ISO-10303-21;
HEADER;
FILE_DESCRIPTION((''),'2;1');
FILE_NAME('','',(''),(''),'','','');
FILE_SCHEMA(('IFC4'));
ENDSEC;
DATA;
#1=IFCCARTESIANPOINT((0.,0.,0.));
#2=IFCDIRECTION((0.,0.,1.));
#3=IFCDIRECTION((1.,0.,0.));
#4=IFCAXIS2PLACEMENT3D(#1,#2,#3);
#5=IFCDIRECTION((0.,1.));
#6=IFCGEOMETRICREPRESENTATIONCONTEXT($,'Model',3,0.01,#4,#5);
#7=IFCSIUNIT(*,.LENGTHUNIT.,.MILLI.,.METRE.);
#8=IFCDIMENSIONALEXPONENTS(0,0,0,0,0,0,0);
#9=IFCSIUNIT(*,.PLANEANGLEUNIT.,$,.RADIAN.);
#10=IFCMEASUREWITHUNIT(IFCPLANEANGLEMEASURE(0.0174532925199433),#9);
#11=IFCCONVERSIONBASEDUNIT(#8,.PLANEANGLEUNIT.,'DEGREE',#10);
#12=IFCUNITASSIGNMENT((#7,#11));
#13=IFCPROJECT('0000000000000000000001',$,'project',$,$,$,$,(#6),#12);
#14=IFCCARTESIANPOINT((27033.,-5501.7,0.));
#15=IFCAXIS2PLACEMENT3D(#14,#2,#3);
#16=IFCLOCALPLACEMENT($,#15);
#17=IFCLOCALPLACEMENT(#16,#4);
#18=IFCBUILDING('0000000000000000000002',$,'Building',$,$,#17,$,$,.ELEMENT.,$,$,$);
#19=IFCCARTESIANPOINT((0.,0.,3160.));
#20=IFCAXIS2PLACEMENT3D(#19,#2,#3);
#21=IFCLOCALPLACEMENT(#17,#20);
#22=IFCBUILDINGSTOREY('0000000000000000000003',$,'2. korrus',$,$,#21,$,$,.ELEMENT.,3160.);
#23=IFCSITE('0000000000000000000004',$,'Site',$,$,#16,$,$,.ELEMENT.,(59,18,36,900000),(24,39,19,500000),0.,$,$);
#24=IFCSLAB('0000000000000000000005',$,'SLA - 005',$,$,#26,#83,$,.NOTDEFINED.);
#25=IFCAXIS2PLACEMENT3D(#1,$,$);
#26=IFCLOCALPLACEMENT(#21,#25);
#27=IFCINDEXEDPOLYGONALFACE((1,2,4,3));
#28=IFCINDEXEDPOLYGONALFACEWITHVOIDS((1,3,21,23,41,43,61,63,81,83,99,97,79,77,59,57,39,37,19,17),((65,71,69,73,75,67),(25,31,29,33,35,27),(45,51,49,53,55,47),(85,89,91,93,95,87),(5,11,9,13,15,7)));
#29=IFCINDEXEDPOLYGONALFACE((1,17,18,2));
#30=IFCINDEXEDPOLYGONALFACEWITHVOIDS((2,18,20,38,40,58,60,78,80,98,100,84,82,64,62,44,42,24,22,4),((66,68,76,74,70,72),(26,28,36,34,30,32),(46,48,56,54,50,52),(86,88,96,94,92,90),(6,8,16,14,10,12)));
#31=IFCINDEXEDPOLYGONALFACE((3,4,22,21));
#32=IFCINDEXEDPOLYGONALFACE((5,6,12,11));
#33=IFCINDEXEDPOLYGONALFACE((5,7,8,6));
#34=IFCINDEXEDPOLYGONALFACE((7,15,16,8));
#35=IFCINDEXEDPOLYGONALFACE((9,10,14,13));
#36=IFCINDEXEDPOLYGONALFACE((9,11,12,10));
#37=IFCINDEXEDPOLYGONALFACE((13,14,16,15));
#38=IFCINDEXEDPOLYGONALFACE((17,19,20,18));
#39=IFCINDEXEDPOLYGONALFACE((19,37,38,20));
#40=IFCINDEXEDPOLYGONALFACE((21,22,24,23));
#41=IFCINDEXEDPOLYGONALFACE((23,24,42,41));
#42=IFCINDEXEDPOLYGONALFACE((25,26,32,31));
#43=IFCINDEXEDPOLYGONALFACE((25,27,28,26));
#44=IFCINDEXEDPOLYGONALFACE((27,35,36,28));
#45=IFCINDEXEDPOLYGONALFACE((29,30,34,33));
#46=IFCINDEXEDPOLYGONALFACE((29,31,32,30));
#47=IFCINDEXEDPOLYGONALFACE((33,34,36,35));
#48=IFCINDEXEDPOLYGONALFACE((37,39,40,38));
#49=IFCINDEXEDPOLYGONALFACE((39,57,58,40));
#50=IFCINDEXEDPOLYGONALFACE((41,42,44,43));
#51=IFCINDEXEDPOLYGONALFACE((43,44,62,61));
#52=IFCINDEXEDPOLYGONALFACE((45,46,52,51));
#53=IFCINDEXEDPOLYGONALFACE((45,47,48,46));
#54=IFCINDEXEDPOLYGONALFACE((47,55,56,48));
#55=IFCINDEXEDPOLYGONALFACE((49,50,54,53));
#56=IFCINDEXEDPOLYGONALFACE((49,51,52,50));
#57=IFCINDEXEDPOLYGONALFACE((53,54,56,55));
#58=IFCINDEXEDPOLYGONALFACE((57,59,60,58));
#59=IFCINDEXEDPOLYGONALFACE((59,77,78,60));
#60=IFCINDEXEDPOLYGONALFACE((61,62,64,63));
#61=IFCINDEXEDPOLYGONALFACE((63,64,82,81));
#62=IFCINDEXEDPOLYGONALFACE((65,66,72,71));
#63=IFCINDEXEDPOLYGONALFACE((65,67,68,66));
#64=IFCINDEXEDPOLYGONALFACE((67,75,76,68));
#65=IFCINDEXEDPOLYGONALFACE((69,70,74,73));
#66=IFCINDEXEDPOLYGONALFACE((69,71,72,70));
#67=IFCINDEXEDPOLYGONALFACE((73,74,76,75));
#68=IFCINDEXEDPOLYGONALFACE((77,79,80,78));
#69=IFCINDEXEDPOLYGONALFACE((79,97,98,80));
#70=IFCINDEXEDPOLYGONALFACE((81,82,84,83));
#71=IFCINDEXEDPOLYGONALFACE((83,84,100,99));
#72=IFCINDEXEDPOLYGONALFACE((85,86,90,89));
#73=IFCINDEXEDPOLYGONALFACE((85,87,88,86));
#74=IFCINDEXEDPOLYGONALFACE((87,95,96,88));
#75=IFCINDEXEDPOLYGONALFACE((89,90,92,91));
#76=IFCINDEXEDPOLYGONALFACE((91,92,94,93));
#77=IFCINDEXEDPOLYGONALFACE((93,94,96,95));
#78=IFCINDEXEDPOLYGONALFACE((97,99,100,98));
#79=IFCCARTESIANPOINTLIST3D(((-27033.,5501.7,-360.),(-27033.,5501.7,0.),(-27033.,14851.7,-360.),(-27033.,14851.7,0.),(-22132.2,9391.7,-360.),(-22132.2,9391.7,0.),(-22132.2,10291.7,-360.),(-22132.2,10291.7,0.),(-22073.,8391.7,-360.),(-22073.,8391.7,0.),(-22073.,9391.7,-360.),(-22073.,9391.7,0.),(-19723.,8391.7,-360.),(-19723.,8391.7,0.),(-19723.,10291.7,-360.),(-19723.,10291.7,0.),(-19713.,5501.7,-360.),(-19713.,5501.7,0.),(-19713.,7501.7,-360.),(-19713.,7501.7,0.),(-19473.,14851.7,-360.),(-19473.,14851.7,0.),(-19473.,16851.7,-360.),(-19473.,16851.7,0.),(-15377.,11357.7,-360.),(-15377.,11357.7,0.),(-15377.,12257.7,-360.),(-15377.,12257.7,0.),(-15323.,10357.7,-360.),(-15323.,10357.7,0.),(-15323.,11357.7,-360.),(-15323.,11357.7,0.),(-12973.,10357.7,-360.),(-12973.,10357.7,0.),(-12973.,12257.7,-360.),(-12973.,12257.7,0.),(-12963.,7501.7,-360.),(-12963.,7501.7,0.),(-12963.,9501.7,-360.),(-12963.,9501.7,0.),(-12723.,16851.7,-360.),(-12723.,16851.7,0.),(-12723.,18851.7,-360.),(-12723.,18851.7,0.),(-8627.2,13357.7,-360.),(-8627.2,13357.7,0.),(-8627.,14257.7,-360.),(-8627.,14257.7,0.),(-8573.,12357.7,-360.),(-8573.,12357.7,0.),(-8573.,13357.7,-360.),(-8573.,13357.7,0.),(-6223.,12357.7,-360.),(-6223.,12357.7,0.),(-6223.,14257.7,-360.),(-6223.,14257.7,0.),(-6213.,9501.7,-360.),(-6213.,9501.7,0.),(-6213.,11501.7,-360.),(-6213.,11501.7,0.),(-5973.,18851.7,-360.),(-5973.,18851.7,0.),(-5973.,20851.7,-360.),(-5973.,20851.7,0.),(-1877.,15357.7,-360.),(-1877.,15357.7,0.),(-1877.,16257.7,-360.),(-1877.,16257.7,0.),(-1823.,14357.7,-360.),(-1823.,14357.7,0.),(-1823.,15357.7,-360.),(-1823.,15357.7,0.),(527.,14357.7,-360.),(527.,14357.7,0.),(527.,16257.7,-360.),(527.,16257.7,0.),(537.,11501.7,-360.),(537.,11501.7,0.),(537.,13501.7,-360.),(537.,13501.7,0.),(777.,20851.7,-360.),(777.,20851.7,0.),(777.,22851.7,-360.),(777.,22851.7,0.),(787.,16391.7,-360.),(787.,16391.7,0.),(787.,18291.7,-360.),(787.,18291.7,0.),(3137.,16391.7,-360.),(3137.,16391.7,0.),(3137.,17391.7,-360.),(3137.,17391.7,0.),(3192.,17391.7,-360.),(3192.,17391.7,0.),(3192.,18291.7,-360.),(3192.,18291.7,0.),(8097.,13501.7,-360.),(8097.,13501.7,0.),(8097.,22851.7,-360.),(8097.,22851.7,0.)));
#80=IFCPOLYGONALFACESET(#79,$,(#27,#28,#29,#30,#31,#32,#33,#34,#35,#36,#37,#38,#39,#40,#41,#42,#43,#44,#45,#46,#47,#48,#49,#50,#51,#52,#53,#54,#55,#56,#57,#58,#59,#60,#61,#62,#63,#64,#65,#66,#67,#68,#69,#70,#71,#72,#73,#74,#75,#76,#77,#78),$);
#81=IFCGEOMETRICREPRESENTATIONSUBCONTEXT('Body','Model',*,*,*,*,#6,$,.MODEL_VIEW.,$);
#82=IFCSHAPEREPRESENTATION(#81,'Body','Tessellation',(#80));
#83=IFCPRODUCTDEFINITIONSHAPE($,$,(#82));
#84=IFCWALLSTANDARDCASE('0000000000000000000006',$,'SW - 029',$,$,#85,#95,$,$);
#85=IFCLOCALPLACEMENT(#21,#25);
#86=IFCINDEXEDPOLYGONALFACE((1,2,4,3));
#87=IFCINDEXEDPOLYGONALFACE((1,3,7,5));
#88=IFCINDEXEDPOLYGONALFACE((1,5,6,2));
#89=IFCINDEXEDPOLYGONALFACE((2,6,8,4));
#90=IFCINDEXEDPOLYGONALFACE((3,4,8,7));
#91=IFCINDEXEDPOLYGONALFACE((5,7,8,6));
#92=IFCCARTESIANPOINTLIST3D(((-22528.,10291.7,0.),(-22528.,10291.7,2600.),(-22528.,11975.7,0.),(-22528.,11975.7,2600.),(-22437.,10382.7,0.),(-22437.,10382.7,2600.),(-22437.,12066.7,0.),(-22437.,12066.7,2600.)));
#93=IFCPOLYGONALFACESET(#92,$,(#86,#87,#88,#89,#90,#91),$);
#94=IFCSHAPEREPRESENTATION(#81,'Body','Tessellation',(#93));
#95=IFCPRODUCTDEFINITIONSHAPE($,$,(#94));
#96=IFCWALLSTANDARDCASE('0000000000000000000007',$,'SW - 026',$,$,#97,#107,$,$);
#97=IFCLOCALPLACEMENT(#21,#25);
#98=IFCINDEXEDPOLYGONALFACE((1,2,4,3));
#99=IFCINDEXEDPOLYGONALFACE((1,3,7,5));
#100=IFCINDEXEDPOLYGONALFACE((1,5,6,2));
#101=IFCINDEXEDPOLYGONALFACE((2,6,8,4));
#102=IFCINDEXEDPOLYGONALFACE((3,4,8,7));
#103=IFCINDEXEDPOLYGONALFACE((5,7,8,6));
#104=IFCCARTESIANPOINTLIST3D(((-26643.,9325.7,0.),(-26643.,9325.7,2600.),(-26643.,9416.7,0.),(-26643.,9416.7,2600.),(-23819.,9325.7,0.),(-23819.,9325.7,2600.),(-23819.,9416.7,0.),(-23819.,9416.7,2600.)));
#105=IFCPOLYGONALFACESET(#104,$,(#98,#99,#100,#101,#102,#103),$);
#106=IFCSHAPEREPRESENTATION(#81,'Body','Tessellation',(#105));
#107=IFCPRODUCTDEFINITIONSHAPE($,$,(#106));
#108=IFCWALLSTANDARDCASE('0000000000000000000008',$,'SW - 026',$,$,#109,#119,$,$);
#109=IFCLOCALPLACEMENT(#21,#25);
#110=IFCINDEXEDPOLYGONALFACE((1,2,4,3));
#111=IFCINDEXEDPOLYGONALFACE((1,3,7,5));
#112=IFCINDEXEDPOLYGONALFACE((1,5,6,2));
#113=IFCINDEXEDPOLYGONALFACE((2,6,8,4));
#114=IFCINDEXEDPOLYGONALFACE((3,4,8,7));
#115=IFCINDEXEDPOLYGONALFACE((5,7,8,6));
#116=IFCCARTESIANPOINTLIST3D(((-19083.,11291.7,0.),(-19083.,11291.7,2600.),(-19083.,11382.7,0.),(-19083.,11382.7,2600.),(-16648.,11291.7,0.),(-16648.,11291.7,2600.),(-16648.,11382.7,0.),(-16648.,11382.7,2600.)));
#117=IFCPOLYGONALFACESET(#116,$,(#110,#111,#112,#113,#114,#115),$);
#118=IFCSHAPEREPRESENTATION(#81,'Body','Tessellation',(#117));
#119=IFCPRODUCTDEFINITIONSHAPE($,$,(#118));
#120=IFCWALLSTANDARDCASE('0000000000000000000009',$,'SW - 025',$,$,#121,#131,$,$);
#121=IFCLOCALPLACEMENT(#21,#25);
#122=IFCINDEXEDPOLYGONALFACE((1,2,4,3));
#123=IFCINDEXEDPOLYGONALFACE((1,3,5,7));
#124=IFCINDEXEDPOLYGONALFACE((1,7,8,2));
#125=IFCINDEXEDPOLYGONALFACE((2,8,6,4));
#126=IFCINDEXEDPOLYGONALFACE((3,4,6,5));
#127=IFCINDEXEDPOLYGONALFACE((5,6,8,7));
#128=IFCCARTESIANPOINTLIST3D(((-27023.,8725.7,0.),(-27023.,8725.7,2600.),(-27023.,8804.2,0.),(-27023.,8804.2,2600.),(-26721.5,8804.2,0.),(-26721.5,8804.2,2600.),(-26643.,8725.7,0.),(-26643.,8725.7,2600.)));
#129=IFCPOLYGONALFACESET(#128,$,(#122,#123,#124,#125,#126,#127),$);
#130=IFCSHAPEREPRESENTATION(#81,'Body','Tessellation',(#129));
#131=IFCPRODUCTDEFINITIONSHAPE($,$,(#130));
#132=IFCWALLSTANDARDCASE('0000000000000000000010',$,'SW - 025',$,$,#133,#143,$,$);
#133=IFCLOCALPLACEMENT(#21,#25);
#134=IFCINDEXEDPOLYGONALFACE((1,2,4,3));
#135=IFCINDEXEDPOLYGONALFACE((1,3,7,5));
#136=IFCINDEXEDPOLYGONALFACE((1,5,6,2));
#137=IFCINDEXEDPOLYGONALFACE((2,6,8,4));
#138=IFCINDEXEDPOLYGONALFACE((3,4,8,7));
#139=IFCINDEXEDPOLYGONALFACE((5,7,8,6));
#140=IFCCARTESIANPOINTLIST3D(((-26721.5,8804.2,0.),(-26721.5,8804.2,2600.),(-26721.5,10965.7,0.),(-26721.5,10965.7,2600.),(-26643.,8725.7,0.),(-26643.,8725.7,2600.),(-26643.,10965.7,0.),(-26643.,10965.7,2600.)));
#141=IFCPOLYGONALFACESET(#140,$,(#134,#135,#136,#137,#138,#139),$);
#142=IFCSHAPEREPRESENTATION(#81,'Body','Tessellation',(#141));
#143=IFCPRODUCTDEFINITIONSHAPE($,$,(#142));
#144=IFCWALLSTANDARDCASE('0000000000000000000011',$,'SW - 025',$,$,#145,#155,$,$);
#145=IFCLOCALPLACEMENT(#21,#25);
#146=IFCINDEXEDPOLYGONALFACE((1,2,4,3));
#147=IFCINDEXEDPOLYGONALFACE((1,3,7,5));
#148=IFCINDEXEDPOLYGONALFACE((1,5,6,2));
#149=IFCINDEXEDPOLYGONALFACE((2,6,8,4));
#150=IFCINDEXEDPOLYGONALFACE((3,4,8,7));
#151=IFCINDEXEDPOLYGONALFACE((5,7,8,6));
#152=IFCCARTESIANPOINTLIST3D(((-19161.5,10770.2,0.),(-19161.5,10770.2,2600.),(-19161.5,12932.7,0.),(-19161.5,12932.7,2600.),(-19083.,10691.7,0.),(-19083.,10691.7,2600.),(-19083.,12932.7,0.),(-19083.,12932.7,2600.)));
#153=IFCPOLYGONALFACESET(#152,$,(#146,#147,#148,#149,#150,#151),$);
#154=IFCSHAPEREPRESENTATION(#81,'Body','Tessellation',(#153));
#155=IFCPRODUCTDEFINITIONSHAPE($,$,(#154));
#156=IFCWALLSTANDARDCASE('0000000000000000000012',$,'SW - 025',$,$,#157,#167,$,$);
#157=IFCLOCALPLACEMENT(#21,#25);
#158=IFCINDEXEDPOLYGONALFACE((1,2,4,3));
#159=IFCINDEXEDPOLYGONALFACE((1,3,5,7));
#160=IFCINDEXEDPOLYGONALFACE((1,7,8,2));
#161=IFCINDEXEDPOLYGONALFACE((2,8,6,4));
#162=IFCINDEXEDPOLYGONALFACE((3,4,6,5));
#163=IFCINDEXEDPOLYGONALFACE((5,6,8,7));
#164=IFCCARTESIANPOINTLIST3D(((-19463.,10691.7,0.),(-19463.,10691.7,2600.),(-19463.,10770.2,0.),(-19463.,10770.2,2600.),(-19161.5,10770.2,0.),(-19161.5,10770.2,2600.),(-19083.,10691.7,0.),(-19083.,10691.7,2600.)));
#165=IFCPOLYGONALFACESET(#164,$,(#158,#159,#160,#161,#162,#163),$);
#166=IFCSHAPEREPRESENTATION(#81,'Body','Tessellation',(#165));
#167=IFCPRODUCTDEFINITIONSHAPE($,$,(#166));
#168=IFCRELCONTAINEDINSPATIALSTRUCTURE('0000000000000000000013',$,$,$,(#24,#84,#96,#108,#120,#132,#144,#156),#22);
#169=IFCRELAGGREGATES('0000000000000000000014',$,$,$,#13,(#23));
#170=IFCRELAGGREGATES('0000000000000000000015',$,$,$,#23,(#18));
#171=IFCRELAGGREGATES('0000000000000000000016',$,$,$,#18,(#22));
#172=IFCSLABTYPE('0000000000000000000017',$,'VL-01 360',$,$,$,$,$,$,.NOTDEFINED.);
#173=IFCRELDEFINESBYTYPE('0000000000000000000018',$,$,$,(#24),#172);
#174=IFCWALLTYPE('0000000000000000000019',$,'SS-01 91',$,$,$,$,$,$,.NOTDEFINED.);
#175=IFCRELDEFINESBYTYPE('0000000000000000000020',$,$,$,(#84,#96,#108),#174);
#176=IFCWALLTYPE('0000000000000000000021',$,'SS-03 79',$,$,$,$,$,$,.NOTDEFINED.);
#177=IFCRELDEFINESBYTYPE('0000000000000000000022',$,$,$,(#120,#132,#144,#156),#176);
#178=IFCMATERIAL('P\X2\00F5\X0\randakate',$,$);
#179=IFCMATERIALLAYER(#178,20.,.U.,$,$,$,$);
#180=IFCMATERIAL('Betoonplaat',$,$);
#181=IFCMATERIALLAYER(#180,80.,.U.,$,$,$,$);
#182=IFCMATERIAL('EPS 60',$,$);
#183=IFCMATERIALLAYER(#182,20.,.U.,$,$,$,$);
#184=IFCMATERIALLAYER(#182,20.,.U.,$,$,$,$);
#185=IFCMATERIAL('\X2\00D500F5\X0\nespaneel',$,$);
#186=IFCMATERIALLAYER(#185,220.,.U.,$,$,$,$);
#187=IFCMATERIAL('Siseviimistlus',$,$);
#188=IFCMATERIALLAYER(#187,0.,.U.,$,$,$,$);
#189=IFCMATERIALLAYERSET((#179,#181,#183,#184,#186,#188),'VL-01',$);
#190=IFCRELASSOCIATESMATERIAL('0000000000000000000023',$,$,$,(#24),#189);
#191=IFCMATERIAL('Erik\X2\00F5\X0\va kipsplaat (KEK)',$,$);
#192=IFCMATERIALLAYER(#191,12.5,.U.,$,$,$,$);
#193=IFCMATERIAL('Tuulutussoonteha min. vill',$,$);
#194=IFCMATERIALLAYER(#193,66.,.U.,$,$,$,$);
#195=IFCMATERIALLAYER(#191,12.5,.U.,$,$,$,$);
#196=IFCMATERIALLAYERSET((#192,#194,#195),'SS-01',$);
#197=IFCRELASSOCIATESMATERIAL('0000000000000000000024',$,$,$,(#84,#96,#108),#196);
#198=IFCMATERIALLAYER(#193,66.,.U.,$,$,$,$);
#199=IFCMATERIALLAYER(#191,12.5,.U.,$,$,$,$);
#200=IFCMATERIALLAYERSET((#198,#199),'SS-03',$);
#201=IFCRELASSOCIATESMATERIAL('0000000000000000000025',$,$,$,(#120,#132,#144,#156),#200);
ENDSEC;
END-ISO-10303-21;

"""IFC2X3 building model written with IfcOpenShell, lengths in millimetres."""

from ifc_helpers import new_model, entity, si_unit, converted_unit, direction, frame, origin_with_axes, place, context, subcontext, project, spatial, polyline, outline, extrude, material, layer, layer_set, layer_usage, type_object, element, save


model = new_model("IFC2X3")

# Units and contexts
model_context = context("Model", 3, precision=0.01, world=origin_with_axes(), true_north=direction((0.0, 1.0)))
body_context = subcontext(model_context, "Body", "Model", "MODEL_VIEW")
ifc_project = project(units=[si_unit("LENGTHUNIT", "METRE", prefix="MILLI"), converted_unit("PLANEANGLEUNIT", "DEGREE", entity("IfcPlaneAngleMeasure", 0.0174532925199433), si_unit("PLANEANGLEUNIT", "RADIAN"), dimensions=[0, 0, 0, 0, 0, 0, 0])], contexts=[model_context])

# Site, building, storey
site_placement = place(None, frame((27033.0, -5501.7, 0.0), z_axis=(0.0, 0.0, 1.0), x_axis=(1.0, 0.0, 0.0)))
site = spatial("IfcSite", under=ifc_project, at=site_placement, Name="Site", CompositionType="ELEMENT", RefLatitude=(59, 18, 36, 900000), RefLongitude=(24, 39, 19, 500000), RefElevation=0.0)
building_placement = place(site_placement, origin_with_axes())
building = spatial("IfcBuilding", under=site, at=building_placement, Name="Building", CompositionType="ELEMENT")
storey_placement = place(building_placement, frame((0.0, 0.0, 3160.0), z_axis=(0.0, 0.0, 1.0), x_axis=(1.0, 0.0, 0.0)))
storey = spatial("IfcBuildingStorey", under=building, at=storey_placement, Name="2. korrus", CompositionType="ELEMENT", Elevation=3160.0)

# Slab
ifc_material_1 = material(Name="Põrandakate")
ifc_material_2 = material(Name="Betoonplaat")
ifc_material_3 = material(Name="Õõnespaneel")
ifc_material_4 = material(Name="Siseviimistlus")
ifc_layer_1 = layer(ifc_material_1, 20.0, ventilated="UNKNOWN")
ifc_layer_2 = layer(ifc_material_2, 80.0, ventilated="UNKNOWN")
ifc_material_5 = material(Name="EPS 60")
ifc_layer_3 = layer(ifc_material_5, 20.0, ventilated="UNKNOWN")
ifc_layer_4 = layer(ifc_material_5, 20.0, ventilated="UNKNOWN")
ifc_layer_5 = layer(ifc_material_3, 220.0, ventilated="UNKNOWN")
ifc_layer_6 = layer(ifc_material_4, 0.0, ventilated="UNKNOWN")
ifc_layer_set_1 = layer_set([ifc_layer_1, ifc_layer_2, ifc_layer_3, ifc_layer_4, ifc_layer_5, ifc_layer_6], Name="VL-01")
ifc_layer_usage_1 = layer_usage(ifc_layer_set_1, "AXIS3", "NEGATIVE", 360.0)
slab_type_1 = type_object("IfcSlabType", Name="VL-01 360", PredefinedType="NOTDEFINED")
slab_1_placement = place(storey_placement, frame((-27033.0, 14851.7, 0.0), z_axis=(0.0, 0.0, 1.0), x_axis=(1.0, 0.0, 0.0)))
element("IfcSlab", 1, at=slab_1_placement, inside=storey, type_object=slab_type_1, material=ifc_layer_usage_1, Name="SLA - 005", PredefinedType="NOTDEFINED", context=body_context, shape_type="SweptSolid", body=[
    extrude(outline(polyline([(0.0, 0.0), (0.0, -9350.0), (7320.0, -9350.0), (7320.0, -7350.0), (14070.0, -7350.0), (14070.0, -5350.0), (20820.0, -5350.0), (20820.0, -3350.0), (27570.0, -3350.0), (27570.0, -1350.0), (35130.0, -1350.0), (35130.0, 8000.0), (27810.0, 8000.0), (27810.0, 6000.0), (21060.0, 6000.0), (21060.0, 4000.0), (14310.0, 4000.0), (14310.0, 2000.0), (7560.0, 2000.0), (7560.0, 0.0), (0.0, 0.0)]), holes=[polyline([(4960.0, -6460.0), (4960.0, -5460.0), (4900.8, -5460.0), (4900.8, -4560.0), (7310.0, -4560.0), (7310.0, -6460.0), (4960.0, -6460.0)]), polyline([(11656.0, -2594.0), (14060.0, -2594.0), (14060.0, -4494.0), (11710.0, -4494.0), (11710.0, -3494.0), (11656.0, -3494.0), (11656.0, -2594.0)]), polyline([(18405.8, -1494.0), (18406.0, -594.0), (20810.0, -594.0), (20810.0, -2494.0), (18460.0, -2494.0), (18460.0, -1494.0), (18405.8, -1494.0)]), polyline([(25156.0, 1406.0), (27560.0, 1406.0), (27560.0, -494.0), (25210.0, -494.0), (25210.0, 506.0), (25156.0, 506.0), (25156.0, 1406.0)]), polyline([(27820.0, 1540.0), (27820.0, 3440.0), (30225.0, 3440.0), (30225.0, 2540.0), (30170.0, 2540.0), (30170.0, 1540.0), (27820.0, 1540.0)])]), frame((0.0, 0.0, -360.0), z_axis=(0.0, 0.0, 1.0), x_axis=(1.0, 0.0, 0.0)), (0.0, 0.0, 1.0), 360.0),
])

# Shared definitions
ifc_material_6 = material(Name="Erikõva kipsplaat (KEK)")
ifc_layer_7 = layer(ifc_material_6, 12.5, ventilated="UNKNOWN")
ifc_material_7 = material(Name="Tuulutussoonteha min. vill")
ifc_layer_8 = layer(ifc_material_7, 66.0, ventilated="UNKNOWN")
ifc_layer_9 = layer(ifc_material_6, 12.5, ventilated="UNKNOWN")
ifc_layer_set_2 = layer_set([ifc_layer_7, ifc_layer_8, ifc_layer_9], Name="SS-01")
wall_type_1 = type_object("IfcWallType", Name="SS-01 91", PredefinedType="NOTDEFINED")

# Wall
ifc_layer_usage_2 = layer_usage(ifc_layer_set_2, "AXIS2", "POSITIVE", -91.0)
wall_1_placement = place(storey_placement, frame((-22528.0, 10291.7, 0.0), z_axis=(0.0, 0.0, 1.0), x_axis=(0.0, 1.0, 0.0)))
element("IfcWallStandardCase", 2, at=wall_1_placement, inside=storey, type_object=wall_type_1, material=ifc_layer_usage_2, Name="SW - 029", context=body_context, shape_type="SweptSolid", body=[
    extrude(outline(polyline([(91.0, -91.0), (1775.0, -91.0), (1684.0, 0.0), (0.0, 0.0), (91.0, -91.0)])), origin_with_axes(), (0.0, 0.0, 1.0), 2600.0),
])

# Wall
ifc_layer_usage_3 = layer_usage(ifc_layer_set_2, "AXIS2", "NEGATIVE", 91.0)
wall_2_placement = place(storey_placement, frame((-26643.0, 9325.7, 0.0), z_axis=(0.0, 0.0, 1.0), x_axis=(1.0, 0.0, 0.0)))
element("IfcWallStandardCase", 3, at=wall_2_placement, inside=storey, type_object=wall_type_1, material=ifc_layer_usage_3, Name="SW - 026", context=body_context, shape_type="SweptSolid", body=[
    extrude(outline(polyline([(0.0, 0.0), (2824.0, 0.0), (2824.0, 91.0), (0.0, 91.0), (0.0, 0.0)])), origin_with_axes(), (0.0, 0.0, 1.0), 2600.0),
])

# Walls
ifc_layer_usage_4 = layer_usage(ifc_layer_set_2, "AXIS2", "NEGATIVE", 91.0)
wall_3_placement = place(storey_placement, frame((-19083.0, 11291.7, 0.0), z_axis=(0.0, 0.0, 1.0), x_axis=(1.0, 0.0, 0.0)))
element("IfcWallStandardCase", 4, at=wall_3_placement, inside=storey, type_object=wall_type_1, material=ifc_layer_usage_4, Name="SW - 026", context=body_context, shape_type="SweptSolid", body=[
    extrude(outline(polyline([(0.0, 0.0), (2435.0, 0.0), (2435.0, 91.0), (0.0, 91.0), (0.0, 0.0)])), origin_with_axes(), (0.0, 0.0, 1.0), 2600.0),
])
ifc_layer_10 = layer(ifc_material_7, 66.0, ventilated="UNKNOWN")
ifc_layer_11 = layer(ifc_material_6, 12.5, ventilated="UNKNOWN")
ifc_layer_set_3 = layer_set([ifc_layer_10, ifc_layer_11], Name="SS-03")
ifc_layer_usage_5 = layer_usage(ifc_layer_set_3, "AXIS2", "NEGATIVE", 78.5)
wall_type_2 = type_object("IfcWallType", Name="SS-03 79", PredefinedType="NOTDEFINED")
wall_4_placement = place(storey_placement, frame((-27023.0, 8725.7, 0.0), z_axis=(0.0, 0.0, 1.0), x_axis=(1.0, 0.0, 0.0)))
element("IfcWallStandardCase", 5, at=wall_4_placement, inside=storey, type_object=wall_type_2, material=ifc_layer_usage_5, Name="SW - 025", context=body_context, shape_type="SweptSolid", body=[
    extrude(outline(polyline([(0.0, 0.0), (380.0, 0.0), (301.5, 78.5), (0.0, 78.5), (0.0, 0.0)])), origin_with_axes(), (0.0, 0.0, 1.0), 2600.0),
])
ifc_layer_usage_6 = layer_usage(ifc_layer_set_3, "AXIS2", "NEGATIVE", 78.5)
wall_5_placement = place(storey_placement, frame((-26643.0, 8725.7, 0.0), z_axis=(0.0, 0.0, 1.0), x_axis=(0.0, 1.0, 0.0)))
element("IfcWallStandardCase", 6, at=wall_5_placement, inside=storey, type_object=wall_type_2, material=ifc_layer_usage_6, Name="SW - 025", context=body_context, shape_type="SweptSolid", body=[
    extrude(outline(polyline([(0.0, 0.0), (2240.0, 0.0), (2240.0, 78.5), (78.5, 78.5), (0.0, 0.0)])), origin_with_axes(), (0.0, 0.0, 1.0), 2600.0),
])
ifc_layer_usage_7 = layer_usage(ifc_layer_set_3, "AXIS2", "NEGATIVE", 78.5)
wall_6_placement = place(storey_placement, frame((-19083.0, 10691.7, 0.0), z_axis=(0.0, 0.0, 1.0), x_axis=(0.0, 1.0, 0.0)))
element("IfcWallStandardCase", 7, at=wall_6_placement, inside=storey, type_object=wall_type_2, material=ifc_layer_usage_7, Name="SW - 025", context=body_context, shape_type="SweptSolid", body=[
    extrude(outline(polyline([(0.0, 0.0), (2241.0, 0.0), (2241.0, 78.5), (78.5, 78.5), (0.0, 0.0)])), origin_with_axes(), (0.0, 0.0, 1.0), 2600.0),
])
ifc_layer_usage_8 = layer_usage(ifc_layer_set_3, "AXIS2", "NEGATIVE", 78.5)
wall_7_placement = place(storey_placement, frame((-19463.0, 10691.7, 0.0), z_axis=(0.0, 0.0, 1.0), x_axis=(1.0, 0.0, 0.0)))
element("IfcWallStandardCase", 8, at=wall_7_placement, inside=storey, type_object=wall_type_2, material=ifc_layer_usage_8, Name="SW - 025", context=body_context, shape_type="SweptSolid", body=[
    extrude(outline(polyline([(0.0, 0.0), (380.0, 0.0), (301.5, 78.5), (0.0, 78.5), (0.0, 0.0)])), origin_with_axes(), (0.0, 0.0, 1.0), 2600.0),
])

save(model, "model.ifc")
